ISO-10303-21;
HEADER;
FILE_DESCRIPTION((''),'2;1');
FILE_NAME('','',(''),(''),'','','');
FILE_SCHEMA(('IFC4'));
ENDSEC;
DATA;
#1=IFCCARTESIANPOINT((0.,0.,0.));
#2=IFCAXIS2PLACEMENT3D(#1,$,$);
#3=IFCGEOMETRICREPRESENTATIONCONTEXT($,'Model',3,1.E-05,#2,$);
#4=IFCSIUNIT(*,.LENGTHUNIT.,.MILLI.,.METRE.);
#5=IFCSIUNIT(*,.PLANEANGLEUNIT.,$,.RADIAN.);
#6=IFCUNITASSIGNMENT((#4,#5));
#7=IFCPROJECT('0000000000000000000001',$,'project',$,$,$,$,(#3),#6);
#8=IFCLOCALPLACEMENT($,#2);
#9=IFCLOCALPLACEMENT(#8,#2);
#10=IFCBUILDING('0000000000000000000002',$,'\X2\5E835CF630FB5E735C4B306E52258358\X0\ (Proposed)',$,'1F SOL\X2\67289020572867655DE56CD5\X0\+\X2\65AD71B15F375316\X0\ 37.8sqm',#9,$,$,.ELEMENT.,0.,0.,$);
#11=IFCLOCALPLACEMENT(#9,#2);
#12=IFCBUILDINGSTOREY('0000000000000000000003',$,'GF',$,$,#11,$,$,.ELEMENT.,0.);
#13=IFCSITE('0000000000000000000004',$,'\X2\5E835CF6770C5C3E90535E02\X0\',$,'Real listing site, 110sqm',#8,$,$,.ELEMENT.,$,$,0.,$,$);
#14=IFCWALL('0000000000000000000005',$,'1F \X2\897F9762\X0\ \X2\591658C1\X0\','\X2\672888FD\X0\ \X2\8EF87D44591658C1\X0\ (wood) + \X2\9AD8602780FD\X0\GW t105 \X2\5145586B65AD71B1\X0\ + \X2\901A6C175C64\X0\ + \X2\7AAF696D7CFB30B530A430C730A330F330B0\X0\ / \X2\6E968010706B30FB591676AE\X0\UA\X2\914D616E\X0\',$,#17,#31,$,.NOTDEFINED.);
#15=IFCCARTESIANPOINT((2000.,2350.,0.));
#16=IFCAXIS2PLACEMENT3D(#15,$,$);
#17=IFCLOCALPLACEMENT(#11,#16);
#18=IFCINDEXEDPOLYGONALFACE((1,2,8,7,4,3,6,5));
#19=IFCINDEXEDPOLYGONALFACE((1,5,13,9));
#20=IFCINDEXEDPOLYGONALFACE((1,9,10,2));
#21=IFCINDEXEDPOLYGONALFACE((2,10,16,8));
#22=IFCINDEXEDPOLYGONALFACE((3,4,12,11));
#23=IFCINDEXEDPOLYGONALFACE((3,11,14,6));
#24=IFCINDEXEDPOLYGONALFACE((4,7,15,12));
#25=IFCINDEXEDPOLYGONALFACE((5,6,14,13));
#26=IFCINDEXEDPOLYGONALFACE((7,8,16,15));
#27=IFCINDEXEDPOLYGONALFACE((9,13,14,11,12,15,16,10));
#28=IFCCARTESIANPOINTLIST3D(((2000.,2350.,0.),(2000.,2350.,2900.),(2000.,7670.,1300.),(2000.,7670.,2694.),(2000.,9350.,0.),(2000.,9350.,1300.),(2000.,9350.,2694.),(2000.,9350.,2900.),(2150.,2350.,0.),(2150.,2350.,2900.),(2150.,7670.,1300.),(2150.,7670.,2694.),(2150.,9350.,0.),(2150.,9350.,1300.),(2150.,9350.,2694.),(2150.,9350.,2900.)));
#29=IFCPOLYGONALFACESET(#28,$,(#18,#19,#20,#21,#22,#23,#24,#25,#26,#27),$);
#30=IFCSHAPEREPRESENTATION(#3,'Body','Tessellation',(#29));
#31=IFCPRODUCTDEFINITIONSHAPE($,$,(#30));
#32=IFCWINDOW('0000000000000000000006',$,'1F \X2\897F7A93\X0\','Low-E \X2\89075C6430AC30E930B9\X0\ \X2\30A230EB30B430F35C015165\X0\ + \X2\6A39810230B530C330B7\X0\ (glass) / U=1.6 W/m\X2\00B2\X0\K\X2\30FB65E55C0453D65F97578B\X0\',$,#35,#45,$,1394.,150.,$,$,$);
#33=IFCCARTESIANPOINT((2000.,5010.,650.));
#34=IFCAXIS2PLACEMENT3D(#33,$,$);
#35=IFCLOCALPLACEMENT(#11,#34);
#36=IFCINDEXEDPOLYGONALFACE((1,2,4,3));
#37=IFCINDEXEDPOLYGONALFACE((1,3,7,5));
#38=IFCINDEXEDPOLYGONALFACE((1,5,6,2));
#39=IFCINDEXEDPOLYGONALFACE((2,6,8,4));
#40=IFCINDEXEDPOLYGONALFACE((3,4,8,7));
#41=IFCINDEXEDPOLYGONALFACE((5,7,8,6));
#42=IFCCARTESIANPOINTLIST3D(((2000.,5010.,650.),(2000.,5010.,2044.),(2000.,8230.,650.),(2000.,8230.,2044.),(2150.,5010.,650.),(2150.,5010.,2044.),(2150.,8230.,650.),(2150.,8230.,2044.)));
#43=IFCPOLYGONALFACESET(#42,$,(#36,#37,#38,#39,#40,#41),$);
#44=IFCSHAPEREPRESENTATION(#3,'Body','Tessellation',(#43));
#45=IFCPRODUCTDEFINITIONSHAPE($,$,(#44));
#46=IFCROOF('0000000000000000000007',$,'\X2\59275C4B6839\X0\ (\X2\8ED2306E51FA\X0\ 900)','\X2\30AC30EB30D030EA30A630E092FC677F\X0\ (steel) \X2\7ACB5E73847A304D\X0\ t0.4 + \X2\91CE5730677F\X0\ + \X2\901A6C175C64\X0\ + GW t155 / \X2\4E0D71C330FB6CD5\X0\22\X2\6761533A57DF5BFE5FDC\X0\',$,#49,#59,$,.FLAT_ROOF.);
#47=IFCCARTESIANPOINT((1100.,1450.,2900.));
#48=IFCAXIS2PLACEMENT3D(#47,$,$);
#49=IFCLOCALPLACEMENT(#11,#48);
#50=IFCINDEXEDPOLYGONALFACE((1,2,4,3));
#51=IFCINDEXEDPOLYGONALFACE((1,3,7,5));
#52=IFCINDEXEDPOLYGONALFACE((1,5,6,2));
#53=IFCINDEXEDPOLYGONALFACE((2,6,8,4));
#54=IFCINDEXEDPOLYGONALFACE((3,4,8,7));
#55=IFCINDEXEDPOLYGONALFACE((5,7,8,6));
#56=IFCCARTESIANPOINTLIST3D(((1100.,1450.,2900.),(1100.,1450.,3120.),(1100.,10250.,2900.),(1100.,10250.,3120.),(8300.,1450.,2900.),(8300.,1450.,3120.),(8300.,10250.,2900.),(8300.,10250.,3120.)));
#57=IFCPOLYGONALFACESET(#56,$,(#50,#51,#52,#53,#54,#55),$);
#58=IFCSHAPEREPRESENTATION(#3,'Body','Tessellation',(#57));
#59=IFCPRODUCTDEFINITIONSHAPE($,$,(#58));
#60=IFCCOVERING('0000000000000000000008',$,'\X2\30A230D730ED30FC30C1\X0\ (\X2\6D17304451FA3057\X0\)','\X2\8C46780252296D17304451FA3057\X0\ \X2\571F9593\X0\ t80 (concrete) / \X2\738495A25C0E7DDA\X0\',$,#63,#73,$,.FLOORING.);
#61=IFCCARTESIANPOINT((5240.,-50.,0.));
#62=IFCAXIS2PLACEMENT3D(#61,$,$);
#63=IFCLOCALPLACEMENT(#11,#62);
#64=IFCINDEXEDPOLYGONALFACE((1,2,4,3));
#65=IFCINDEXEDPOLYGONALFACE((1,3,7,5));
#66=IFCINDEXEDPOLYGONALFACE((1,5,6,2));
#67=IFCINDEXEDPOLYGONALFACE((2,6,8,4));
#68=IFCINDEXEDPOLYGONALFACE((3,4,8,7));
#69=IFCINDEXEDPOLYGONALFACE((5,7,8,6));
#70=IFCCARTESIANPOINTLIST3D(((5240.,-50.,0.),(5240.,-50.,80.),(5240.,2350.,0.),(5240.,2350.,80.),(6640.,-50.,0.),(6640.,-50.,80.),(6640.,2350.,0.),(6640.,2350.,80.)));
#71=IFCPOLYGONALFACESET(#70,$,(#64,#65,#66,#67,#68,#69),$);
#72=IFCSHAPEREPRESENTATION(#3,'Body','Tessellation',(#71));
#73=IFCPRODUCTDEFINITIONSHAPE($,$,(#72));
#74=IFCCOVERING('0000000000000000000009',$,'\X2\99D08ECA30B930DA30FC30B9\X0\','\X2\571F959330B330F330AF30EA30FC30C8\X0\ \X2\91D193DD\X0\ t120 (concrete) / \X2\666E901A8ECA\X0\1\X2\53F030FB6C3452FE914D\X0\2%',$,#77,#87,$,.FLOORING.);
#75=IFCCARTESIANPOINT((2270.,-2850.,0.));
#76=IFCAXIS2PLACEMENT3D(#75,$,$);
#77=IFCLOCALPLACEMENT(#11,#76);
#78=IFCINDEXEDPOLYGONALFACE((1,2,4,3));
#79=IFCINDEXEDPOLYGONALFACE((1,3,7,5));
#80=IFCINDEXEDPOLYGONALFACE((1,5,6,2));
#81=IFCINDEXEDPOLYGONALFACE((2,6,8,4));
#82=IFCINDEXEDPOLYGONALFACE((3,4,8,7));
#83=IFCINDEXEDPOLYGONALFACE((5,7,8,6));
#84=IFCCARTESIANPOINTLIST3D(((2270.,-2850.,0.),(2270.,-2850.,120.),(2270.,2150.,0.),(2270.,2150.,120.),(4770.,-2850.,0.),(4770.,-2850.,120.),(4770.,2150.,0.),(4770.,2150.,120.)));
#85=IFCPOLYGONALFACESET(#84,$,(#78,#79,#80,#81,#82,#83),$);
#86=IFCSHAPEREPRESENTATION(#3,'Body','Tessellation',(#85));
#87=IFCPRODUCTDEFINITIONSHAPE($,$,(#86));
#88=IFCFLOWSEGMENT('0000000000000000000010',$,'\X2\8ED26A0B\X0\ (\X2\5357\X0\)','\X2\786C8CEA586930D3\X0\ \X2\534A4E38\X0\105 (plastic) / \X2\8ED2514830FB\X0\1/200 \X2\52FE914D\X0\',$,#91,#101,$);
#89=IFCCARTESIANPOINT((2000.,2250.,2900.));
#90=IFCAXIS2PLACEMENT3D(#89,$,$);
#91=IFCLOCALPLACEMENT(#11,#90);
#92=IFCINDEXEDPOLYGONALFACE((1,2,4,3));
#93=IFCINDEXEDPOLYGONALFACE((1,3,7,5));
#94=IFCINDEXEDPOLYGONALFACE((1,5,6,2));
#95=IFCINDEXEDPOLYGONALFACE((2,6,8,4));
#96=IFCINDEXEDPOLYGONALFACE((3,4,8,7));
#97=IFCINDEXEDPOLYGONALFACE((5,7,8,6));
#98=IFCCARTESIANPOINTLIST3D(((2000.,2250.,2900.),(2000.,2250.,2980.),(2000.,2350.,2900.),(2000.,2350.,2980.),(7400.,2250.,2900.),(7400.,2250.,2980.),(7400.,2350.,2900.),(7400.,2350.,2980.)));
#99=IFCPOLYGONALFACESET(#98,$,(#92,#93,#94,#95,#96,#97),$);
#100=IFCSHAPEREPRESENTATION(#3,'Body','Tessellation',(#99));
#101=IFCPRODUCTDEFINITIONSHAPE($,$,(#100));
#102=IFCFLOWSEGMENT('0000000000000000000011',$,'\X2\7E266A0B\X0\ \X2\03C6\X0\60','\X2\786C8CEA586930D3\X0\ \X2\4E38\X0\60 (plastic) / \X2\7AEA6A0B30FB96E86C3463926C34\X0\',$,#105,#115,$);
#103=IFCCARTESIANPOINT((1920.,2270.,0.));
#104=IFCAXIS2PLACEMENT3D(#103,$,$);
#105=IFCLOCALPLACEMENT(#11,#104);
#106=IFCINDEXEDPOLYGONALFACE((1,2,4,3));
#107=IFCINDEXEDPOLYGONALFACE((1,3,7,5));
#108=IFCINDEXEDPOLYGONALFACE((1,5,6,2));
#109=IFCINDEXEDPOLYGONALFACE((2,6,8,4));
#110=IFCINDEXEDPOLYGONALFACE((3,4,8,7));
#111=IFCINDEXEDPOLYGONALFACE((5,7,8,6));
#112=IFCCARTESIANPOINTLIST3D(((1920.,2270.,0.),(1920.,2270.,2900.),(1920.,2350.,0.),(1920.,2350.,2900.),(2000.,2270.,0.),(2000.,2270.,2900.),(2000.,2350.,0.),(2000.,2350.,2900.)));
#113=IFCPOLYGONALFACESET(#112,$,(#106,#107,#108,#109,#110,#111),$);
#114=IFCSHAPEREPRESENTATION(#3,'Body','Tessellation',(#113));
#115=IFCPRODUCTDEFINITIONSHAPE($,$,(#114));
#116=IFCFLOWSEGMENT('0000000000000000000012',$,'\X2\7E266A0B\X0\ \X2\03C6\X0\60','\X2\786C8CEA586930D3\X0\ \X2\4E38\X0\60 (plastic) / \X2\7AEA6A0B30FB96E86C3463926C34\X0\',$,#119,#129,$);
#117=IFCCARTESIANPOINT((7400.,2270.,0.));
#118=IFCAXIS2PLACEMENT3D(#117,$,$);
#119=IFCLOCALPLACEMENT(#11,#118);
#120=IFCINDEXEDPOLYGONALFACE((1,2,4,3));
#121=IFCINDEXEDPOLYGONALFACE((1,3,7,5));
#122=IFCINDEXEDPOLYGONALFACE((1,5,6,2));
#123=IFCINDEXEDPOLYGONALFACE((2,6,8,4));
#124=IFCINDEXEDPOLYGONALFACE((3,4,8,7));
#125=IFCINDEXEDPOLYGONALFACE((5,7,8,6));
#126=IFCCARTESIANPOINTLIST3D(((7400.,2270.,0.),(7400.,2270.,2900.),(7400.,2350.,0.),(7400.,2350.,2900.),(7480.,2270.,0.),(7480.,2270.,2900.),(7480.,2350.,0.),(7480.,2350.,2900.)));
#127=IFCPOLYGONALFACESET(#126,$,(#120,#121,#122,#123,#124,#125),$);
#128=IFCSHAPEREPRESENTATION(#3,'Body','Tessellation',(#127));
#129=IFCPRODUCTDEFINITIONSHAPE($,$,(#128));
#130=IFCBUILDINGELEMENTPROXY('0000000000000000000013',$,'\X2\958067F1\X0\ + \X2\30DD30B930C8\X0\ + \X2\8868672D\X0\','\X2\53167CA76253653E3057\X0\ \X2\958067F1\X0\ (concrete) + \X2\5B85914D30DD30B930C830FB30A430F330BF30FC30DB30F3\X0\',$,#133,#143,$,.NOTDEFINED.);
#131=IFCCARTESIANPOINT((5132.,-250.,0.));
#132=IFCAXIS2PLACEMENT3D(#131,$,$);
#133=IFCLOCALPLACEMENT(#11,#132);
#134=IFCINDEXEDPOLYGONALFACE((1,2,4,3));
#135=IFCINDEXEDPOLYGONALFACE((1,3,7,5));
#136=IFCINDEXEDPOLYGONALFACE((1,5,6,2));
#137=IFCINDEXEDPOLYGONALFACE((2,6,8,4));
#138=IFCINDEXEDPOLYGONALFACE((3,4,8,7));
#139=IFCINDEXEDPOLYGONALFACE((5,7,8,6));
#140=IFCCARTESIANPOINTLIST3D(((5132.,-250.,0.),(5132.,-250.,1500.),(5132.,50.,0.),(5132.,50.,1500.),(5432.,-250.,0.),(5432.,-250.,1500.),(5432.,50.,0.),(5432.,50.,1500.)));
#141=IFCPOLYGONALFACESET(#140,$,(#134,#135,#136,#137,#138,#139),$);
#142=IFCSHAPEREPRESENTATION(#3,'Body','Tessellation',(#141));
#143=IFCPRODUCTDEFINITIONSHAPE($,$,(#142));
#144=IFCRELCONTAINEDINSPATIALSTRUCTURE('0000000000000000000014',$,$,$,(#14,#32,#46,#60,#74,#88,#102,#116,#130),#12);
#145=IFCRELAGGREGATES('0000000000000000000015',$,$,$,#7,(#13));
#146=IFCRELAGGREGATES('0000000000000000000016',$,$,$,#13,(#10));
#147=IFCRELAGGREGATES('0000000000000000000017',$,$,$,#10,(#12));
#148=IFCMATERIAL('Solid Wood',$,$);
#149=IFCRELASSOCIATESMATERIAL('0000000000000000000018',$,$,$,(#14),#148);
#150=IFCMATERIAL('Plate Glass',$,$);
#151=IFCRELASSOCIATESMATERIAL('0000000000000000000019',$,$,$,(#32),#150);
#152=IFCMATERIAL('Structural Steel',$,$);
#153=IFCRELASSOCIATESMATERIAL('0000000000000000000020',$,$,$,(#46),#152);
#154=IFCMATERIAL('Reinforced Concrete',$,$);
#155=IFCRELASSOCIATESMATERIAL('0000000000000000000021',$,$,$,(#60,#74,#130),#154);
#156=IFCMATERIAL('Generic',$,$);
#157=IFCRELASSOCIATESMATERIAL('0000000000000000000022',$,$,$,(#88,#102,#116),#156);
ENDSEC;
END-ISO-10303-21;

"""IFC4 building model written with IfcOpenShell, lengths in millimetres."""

from ifc_helpers import new_model, si_unit, frame, frame_2d, origin, place, context, project, spatial, rectangle, extrude, material, element, fill, save


model = new_model("IFC4")

# Units and contexts
model_context = context("Model", 3, precision=1e-05, world=origin())
ifc_project = project(units=[si_unit("LENGTHUNIT", "METRE", prefix="MILLI"), si_unit("PLANEANGLEUNIT", "RADIAN")], contexts=[model_context])

# Site, building, storey
site_placement = place(None, origin())
site = spatial("IfcSite", under=ifc_project, at=site_placement, Name="広島県尾道市", ObjectType="Real listing site, 110sqm", CompositionType="ELEMENT", RefElevation=0.0)
building_placement = place(site_placement, origin())
building = spatial("IfcBuilding", under=site, at=building_placement, Name="広島・平屋の別荘 (Proposed)", ObjectType="1F SOL木造在来工法+断熱強化 37.8sqm", CompositionType="ELEMENT", ElevationOfRefHeight=0.0, ElevationOfTerrain=0.0)
storey_placement = place(building_placement, origin())
storey = spatial("IfcBuildingStorey", under=building, at=storey_placement, Name="GF", CompositionType="ELEMENT", Elevation=0.0)

# Shared definitions
ifc_material_1 = material(Name="Solid Wood")

# Shared definitions
ifc_material_2 = material(Name="Reinforced Concrete")

# Shared definitions
ifc_material_3 = material(Name="Plate Glass")

# Wall, opening, window
wall_1_placement = place(storey_placement, frame((2000.0, 2350.0, 0.0)))
wall_1 = element("IfcWall", 1, at=wall_1_placement, inside=storey, material=ifc_material_1, Name="1F 西面 外壁", Description="木製 軸組外壁 (wood) + 高性能GW t105 充填断熱 + 通気層 + 窯業系サイディング / 準耐火・外皮UA配慮", PredefinedType="NOTDEFINED", context=model_context, shape_type="SweptSolid", body=[
    extrude(rectangle(XDim=150.0, YDim=7000.0, at=frame_2d((75.0, 3500.0))), frame((2000.0, 2350.0, 0.0)), (0.0, 0.0, 1.0), 2900.0),
])
opening_1_placement = place(storey_placement, frame((2000.0, 5010.0, 650.0)))
opening_1 = element("IfcOpeningElement", 2, at=opening_1_placement, cuts=wall_1, PredefinedType="NOTDEFINED", context=model_context, shape_type="SweptSolid", body=[
    extrude(rectangle(XDim=150.0, YDim=3220.0, at=frame_2d((75.0, 1610.0))), frame((2000.0, 5010.0, 650.0)), (0.0, 0.0, 1.0), 1394.0),
])
window_1_placement = place(storey_placement, frame((2000.0, 5010.0, 650.0)))
window_1 = element("IfcWindow", 3, at=window_1_placement, inside=storey, material=ifc_material_3, Name="1F 西窓", Description="Low-E 複層ガラス アルゴン封入 + 樹脂サッシ (glass) / U=1.6 W/m²K・日射取得型", OverallHeight=1394.0, OverallWidth=150.0, context=model_context, shape_type="SweptSolid", body=[
    extrude(rectangle(XDim=150.0, YDim=3220.0, at=frame_2d((75.0, 1610.0))), frame((2000.0, 5010.0, 650.0)), (0.0, 0.0, 1.0), 1394.0),
])
fill(opening_1, window_1)

# Roof
ifc_material_4 = material(Name="Structural Steel")
roof_placement = place(storey_placement, frame((1100.0, 1450.0, 2900.0)))
element("IfcRoof", 4, at=roof_placement, inside=storey, material=ifc_material_4, Name="大屋根 (軒の出 900)", Description="ガルバリウム鋼板 (steel) 立平葺き t0.4 + 野地板 + 通気層 + GW t155 / 不燃・法22条区域対応", PredefinedType="FLAT_ROOF", context=model_context, shape_type="SweptSolid", body=[
    extrude(rectangle(XDim=7200.0, YDim=8800.0, at=frame_2d((3600.0, 4400.0))), frame((1100.0, 1450.0, 2900.0)), (0.0, 0.0, 1.0), 220.0),
])

# Coverings
covering_1_placement = place(storey_placement, frame((5240.0, -50.0, 0.0)))
element("IfcCovering", 5, at=covering_1_placement, inside=storey, material=ifc_material_2, Name="アプローチ (洗い出し)", Description="豆砂利洗い出し 土間 t80 (concrete) / 玄関導線", PredefinedType="FLOORING", context=model_context, shape_type="SweptSolid", body=[
    extrude(rectangle(XDim=1400.0, YDim=2400.0, at=frame_2d((700.0, 1200.0))), frame((5240.0, -50.0, 0.0)), (0.0, 0.0, 1.0), 80.0),
])
covering_2_placement = place(storey_placement, frame((2270.0, -2850.0, 0.0)))
element("IfcCovering", 6, at=covering_2_placement, inside=storey, material=ifc_material_2, Name="駐車スペース", Description="土間コンクリート 金鏝 t120 (concrete) / 普通車1台・水勾配2%", PredefinedType="FLOORING", context=model_context, shape_type="SweptSolid", body=[
    extrude(rectangle(XDim=2500.0, YDim=5000.0, at=frame_2d((1250.0, 2500.0))), frame((2270.0, -2850.0, 0.0)), (0.0, 0.0, 1.0), 120.0),
])

# Flow segments
ifc_material_5 = material(Name="Generic")
flow_segment_1_placement = place(storey_placement, frame((2000.0, 2250.0, 2900.0)))
element("IfcFlowSegment", 7, at=flow_segment_1_placement, inside=storey, material=ifc_material_5, Name="軒樋 (南)", Description="硬質塩ビ 半丸105 (plastic) / 軒先・1/200 勾配", context=model_context, shape_type="SweptSolid", body=[
    extrude(rectangle(XDim=5400.0, YDim=100.0, at=frame_2d((2700.0, 50.0))), frame((2000.0, 2250.0, 2900.0)), (0.0, 0.0, 1.0), 80.0),
])
flow_segment_2_placement = place(storey_placement, frame((1920.0, 2270.0, 0.0)))
element("IfcFlowSegment", 8, at=flow_segment_2_placement, inside=storey, material=ifc_material_5, Name="縦樋 φ60", Description="硬質塩ビ 丸60 (plastic) / 竪樋・雨水排水", context=model_context, shape_type="SweptSolid", body=[
    extrude(rectangle(XDim=80.0, YDim=80.0, at=frame_2d((40.0, 40.0))), frame((1920.0, 2270.0, 0.0)), (0.0, 0.0, 1.0), 2900.0),
])
flow_segment_3_placement = place(storey_placement, frame((7400.0, 2270.0, 0.0)))
element("IfcFlowSegment", 9, at=flow_segment_3_placement, inside=storey, material=ifc_material_5, Name="縦樋 φ60", Description="硬質塩ビ 丸60 (plastic) / 竪樋・雨水排水", context=model_context, shape_type="SweptSolid", body=[
    extrude(rectangle(XDim=80.0, YDim=80.0, at=frame_2d((40.0, 40.0))), frame((7400.0, 2270.0, 0.0)), (0.0, 0.0, 1.0), 2900.0),
])

# Building element proxy
proxy_placement = place(storey_placement, frame((5132.0, -250.0, 0.0)))
element("IfcBuildingElementProxy", 10, at=proxy_placement, inside=storey, material=ifc_material_2, Name="門柱 + ポスト + 表札", Description="化粧打放し 門柱 (concrete) + 宅配ポスト・インターホン", PredefinedType="NOTDEFINED", context=model_context, shape_type="SweptSolid", body=[
    extrude(rectangle(XDim=300.0, YDim=300.0, at=frame_2d((150.0, 150.0))), frame((5132.0, -250.0, 0.0)), (0.0, 0.0, 1.0), 1500.0),
])

save(model, "model.ifc")
